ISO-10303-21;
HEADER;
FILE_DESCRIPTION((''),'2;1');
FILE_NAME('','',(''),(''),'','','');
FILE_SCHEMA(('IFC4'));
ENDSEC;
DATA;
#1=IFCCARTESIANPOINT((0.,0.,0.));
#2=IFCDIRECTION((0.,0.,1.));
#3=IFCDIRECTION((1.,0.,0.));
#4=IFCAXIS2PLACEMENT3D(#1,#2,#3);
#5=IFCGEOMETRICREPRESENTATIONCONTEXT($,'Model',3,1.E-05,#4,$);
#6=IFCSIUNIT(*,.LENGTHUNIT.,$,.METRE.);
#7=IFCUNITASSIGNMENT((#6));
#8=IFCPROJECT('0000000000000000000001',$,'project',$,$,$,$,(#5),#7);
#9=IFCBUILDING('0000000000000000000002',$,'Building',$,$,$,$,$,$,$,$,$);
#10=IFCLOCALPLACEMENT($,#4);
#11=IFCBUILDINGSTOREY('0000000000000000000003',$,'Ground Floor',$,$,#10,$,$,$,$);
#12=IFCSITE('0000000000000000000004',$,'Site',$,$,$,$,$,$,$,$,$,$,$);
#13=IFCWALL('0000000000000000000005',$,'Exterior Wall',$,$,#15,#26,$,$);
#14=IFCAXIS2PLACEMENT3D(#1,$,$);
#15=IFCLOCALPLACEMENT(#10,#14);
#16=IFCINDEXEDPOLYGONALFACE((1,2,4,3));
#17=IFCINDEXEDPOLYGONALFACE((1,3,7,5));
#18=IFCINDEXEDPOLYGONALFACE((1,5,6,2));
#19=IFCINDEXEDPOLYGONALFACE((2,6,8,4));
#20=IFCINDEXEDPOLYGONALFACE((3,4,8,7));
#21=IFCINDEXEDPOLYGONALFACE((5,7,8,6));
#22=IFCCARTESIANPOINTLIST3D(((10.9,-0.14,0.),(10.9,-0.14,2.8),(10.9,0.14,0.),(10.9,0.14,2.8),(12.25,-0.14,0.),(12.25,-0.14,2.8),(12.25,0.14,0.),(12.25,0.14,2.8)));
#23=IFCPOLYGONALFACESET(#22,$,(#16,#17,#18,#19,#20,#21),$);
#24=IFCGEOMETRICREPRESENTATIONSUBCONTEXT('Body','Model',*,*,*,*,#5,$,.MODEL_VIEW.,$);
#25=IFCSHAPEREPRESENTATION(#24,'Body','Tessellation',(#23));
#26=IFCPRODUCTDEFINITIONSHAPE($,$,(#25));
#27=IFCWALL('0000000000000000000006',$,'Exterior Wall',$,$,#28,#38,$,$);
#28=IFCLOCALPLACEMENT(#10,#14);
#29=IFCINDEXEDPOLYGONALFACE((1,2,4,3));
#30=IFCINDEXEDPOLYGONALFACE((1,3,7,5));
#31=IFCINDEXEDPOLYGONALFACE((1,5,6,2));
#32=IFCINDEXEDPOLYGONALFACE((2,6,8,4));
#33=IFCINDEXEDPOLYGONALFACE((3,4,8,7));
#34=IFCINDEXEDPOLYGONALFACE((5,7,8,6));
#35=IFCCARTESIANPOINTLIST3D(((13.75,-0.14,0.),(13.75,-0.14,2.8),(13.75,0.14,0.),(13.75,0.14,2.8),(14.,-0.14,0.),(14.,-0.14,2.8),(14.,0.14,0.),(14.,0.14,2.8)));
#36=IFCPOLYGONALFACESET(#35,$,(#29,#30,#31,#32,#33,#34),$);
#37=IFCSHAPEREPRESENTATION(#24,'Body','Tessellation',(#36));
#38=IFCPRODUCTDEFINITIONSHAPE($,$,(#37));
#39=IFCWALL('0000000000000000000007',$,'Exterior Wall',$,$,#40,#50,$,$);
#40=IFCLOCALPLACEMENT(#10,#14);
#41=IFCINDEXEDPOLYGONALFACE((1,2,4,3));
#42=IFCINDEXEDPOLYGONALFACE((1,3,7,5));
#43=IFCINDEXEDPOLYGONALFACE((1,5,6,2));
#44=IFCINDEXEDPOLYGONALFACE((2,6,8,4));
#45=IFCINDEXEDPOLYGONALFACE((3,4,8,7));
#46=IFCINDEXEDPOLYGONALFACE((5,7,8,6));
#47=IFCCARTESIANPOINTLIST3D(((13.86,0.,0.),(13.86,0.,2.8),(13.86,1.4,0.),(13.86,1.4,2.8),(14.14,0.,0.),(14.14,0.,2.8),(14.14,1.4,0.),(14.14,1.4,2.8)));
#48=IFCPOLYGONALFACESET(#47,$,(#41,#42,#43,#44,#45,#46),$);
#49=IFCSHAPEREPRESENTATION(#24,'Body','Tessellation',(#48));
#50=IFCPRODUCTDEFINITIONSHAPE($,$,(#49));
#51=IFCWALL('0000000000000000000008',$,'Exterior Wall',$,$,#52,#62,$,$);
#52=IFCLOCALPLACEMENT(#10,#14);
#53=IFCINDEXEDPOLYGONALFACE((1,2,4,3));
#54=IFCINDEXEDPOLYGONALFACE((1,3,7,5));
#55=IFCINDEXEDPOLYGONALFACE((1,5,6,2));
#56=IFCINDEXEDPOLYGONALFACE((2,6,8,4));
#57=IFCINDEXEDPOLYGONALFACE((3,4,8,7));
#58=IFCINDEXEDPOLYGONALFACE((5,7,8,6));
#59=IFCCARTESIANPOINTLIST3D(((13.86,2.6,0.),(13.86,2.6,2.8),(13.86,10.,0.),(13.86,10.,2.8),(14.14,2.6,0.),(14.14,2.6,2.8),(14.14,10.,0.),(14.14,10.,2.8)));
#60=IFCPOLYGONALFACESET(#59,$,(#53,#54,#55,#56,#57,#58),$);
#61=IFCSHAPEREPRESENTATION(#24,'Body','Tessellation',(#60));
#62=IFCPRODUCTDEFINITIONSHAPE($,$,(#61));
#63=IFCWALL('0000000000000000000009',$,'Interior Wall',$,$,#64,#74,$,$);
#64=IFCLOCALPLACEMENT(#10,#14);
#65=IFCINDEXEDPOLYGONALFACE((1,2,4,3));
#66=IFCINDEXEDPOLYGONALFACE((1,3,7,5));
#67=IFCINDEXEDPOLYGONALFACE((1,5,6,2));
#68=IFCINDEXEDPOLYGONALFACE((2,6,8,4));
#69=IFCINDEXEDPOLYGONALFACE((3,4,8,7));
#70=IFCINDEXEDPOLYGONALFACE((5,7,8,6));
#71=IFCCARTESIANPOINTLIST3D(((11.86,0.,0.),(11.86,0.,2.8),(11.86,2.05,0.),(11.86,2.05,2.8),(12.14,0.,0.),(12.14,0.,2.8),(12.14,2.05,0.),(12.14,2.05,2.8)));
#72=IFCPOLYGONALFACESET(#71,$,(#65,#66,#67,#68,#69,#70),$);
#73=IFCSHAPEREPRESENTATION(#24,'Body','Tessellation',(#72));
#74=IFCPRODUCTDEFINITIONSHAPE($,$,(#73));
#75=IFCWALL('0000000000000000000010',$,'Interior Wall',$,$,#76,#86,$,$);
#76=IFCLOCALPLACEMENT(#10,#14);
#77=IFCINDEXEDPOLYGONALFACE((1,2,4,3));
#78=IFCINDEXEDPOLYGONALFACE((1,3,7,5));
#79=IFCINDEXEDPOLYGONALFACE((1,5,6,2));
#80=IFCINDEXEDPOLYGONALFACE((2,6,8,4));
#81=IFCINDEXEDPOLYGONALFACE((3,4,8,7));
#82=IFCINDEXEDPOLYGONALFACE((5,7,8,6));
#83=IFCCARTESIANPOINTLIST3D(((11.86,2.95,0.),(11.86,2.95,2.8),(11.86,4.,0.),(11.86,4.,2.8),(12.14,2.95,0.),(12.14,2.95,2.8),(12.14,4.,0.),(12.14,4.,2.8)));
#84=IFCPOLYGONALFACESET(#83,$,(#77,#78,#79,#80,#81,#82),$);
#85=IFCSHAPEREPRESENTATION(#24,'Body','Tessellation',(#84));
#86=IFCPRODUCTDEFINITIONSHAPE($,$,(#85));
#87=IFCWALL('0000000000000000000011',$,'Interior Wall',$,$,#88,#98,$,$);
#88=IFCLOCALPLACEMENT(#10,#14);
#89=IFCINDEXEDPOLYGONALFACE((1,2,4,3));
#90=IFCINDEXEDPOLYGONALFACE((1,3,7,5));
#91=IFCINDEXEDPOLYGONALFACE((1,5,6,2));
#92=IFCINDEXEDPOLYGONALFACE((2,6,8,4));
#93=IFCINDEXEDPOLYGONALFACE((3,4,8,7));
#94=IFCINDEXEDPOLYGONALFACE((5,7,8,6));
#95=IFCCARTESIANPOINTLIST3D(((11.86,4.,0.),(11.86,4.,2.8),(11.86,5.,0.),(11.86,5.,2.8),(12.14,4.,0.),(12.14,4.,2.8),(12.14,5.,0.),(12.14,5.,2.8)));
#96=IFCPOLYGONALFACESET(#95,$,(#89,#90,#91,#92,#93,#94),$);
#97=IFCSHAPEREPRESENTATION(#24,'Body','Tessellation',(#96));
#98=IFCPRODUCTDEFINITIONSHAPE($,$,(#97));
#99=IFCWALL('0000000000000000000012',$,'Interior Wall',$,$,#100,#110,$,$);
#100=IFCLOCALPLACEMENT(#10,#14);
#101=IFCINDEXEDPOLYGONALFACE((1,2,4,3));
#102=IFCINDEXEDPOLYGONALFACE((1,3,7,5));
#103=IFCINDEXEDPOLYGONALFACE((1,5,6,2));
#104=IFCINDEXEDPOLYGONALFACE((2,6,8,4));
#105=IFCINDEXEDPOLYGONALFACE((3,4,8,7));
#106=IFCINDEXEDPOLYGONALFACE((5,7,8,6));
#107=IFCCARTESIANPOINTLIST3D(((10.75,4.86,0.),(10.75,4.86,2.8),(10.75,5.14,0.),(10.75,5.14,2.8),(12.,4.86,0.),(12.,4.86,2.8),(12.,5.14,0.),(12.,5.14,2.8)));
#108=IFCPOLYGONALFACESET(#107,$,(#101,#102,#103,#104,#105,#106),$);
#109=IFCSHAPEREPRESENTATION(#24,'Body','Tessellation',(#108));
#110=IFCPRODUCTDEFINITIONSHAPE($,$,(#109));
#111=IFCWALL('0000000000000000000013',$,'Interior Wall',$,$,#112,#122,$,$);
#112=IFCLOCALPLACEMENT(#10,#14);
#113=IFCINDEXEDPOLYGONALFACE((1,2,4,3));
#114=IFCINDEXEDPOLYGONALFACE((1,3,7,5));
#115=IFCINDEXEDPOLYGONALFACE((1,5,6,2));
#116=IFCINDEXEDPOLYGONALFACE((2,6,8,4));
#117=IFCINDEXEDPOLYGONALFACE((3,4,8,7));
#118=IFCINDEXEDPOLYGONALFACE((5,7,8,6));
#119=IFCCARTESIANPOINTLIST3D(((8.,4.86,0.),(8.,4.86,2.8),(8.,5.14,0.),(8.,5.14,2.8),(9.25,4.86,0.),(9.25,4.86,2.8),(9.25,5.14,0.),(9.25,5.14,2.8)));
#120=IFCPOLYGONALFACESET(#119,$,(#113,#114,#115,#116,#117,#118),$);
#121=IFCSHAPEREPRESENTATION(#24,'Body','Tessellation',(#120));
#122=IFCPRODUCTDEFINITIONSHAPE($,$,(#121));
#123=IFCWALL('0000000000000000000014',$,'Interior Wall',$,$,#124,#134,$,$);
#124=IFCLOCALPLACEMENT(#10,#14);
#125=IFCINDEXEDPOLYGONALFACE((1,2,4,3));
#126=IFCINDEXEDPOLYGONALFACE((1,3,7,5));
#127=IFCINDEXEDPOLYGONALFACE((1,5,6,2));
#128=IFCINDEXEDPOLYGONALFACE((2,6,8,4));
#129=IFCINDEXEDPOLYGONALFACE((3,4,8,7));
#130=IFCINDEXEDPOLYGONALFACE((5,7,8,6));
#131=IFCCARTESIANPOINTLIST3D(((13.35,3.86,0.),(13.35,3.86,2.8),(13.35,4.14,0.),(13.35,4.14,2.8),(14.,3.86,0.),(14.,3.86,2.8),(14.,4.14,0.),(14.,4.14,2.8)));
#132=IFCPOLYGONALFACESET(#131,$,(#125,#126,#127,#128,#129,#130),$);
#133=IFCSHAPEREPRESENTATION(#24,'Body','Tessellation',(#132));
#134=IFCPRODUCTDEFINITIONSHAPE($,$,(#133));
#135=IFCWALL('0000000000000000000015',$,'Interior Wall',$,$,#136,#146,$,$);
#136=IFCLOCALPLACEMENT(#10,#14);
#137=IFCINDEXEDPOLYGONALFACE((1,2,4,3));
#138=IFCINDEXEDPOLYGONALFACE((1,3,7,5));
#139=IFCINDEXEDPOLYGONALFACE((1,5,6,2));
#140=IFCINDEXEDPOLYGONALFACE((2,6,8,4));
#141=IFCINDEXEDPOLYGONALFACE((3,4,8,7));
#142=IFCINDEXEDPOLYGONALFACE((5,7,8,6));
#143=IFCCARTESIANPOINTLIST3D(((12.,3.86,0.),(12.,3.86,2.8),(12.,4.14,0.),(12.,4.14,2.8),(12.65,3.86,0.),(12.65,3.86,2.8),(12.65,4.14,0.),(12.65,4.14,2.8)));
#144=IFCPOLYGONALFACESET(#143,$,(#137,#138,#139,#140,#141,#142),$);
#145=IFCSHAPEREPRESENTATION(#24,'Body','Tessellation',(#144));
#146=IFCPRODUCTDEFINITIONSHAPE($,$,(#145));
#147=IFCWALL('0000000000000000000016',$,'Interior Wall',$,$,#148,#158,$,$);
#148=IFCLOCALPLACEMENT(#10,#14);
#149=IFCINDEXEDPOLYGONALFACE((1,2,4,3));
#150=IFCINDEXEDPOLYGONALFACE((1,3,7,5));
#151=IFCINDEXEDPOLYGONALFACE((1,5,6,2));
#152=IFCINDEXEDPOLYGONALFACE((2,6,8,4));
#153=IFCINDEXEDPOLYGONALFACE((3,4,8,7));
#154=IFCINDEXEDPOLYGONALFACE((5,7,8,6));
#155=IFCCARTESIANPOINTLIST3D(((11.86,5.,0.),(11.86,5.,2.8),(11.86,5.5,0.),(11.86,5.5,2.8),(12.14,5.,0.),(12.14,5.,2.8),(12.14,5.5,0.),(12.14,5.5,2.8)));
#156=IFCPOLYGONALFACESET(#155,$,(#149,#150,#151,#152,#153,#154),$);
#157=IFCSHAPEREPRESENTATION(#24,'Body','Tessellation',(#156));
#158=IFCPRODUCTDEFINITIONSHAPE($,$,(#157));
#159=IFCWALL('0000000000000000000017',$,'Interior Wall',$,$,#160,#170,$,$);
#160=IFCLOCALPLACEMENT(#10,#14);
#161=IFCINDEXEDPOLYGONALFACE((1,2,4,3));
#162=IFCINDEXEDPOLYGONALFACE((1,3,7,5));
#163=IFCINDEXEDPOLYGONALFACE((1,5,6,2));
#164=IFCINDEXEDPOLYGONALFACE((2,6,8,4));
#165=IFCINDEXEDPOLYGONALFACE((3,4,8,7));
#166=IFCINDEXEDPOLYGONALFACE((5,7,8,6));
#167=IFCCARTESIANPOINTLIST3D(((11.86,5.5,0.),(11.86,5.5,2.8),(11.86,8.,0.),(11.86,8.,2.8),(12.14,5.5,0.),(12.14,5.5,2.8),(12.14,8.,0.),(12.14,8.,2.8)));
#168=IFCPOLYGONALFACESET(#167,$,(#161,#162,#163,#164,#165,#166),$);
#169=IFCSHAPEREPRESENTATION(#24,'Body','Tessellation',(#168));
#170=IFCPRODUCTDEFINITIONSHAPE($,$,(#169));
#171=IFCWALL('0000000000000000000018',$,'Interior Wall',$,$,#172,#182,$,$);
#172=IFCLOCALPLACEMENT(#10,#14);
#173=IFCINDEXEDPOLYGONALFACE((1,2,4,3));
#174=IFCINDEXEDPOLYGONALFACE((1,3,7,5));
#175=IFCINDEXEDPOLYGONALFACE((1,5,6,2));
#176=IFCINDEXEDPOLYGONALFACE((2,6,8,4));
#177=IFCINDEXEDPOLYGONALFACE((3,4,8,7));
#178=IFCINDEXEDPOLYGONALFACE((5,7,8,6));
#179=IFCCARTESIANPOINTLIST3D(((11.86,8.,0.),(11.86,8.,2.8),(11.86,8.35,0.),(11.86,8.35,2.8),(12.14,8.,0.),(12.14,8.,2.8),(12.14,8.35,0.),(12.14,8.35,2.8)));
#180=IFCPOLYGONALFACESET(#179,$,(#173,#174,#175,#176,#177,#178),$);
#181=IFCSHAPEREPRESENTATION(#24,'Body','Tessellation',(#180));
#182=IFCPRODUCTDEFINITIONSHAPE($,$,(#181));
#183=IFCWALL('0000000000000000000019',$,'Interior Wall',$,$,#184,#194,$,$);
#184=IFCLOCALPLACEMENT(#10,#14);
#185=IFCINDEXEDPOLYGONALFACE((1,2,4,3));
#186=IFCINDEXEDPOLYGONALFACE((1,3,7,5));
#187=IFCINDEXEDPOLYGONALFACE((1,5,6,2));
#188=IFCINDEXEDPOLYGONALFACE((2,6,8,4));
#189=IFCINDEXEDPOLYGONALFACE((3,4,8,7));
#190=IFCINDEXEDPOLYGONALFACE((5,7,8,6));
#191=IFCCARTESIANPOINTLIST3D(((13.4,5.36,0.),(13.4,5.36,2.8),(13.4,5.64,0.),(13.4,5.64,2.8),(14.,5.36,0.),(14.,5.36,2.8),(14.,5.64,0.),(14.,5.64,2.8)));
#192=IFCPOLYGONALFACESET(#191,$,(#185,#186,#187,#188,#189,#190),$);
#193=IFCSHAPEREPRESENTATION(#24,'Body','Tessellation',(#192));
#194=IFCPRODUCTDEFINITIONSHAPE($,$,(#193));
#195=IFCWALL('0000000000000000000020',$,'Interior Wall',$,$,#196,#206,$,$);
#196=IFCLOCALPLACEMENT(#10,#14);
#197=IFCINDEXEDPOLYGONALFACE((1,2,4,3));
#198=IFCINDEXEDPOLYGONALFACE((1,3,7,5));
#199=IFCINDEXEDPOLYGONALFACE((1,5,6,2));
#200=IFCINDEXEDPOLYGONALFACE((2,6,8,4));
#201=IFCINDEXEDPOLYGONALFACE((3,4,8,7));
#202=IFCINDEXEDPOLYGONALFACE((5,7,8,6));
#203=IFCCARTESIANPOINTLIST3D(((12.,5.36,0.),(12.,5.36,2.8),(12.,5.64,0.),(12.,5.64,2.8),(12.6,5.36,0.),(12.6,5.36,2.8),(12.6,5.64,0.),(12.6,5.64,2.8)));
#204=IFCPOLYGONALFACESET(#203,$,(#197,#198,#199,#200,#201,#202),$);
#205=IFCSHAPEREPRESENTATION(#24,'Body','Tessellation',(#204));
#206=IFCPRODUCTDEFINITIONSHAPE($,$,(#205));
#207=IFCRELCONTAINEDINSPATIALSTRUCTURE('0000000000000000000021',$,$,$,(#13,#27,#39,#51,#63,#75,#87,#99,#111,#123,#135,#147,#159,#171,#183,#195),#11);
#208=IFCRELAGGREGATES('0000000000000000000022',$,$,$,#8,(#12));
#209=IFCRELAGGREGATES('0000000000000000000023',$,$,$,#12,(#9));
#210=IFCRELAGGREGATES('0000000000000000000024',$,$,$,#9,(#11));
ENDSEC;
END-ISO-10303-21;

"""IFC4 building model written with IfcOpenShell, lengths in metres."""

from ifc_helpers import new_model, si_unit, frame, origin_with_axes, place, context, subcontext, project, spatial, indexed_curve, outline, extrude, element, save


model = new_model("IFC4")

# Units and contexts
model_context = context("Model", 3, precision=1e-05, world=origin_with_axes())
body_context = subcontext(model_context, "Body", "Model", "MODEL_VIEW")
ifc_project = project(units=[si_unit("LENGTHUNIT", "METRE")], contexts=[model_context])

# Site, building, storey
site = spatial("IfcSite", under=ifc_project, Name="Site")
building = spatial("IfcBuilding", under=site, Name="Building")
storey_placement = place(None, origin_with_axes())
storey = spatial("IfcBuildingStorey", under=building, at=storey_placement, Name="Ground Floor")

# Walls
wall_1_placement = place(storey_placement, frame((10.9, 0.0, 0.0), z_axis=(0.0, 0.0, 1.0), x_axis=(1.0, 0.0, 0.0)))
element("IfcWall", 1, at=wall_1_placement, inside=storey, Name="Exterior Wall", context=body_context, shape_type="SweptSolid", body=[
    extrude(outline(indexed_curve([(0.0, 0.0), (0.0, 0.28), (1.35, 0.28), (1.35, 0.0), (0.0, 0.0)], self_intersect=False)), frame((0.0, -0.14, 0.0), z_axis=(0.0, 0.0, 1.0), x_axis=(1.0, 0.0, 0.0)), (0.0, 0.0, 1.0), 2.8),
])
wall_2_placement = place(storey_placement, frame((13.75, 0.0, 0.0), z_axis=(0.0, 0.0, 1.0), x_axis=(1.0, 0.0, 0.0)))
element("IfcWall", 2, at=wall_2_placement, inside=storey, Name="Exterior Wall", context=body_context, shape_type="SweptSolid", body=[
    extrude(outline(indexed_curve([(0.0, 0.0), (0.0, 0.28), (0.25, 0.28), (0.25, 0.0), (0.0, 0.0)], self_intersect=False)), frame((0.0, -0.14, 0.0), z_axis=(0.0, 0.0, 1.0), x_axis=(1.0, 0.0, 0.0)), (0.0, 0.0, 1.0), 2.8),
])
wall_3_placement = place(storey_placement, frame((14.0, 0.0, 0.0), z_axis=(0.0, 0.0, 1.0), x_axis=(0.0, 1.0, 0.0)))
element("IfcWall", 3, at=wall_3_placement, inside=storey, Name="Exterior Wall", context=body_context, shape_type="SweptSolid", body=[
    extrude(outline(indexed_curve([(0.0, 0.0), (0.0, 0.28), (1.4, 0.28), (1.4, 0.0), (0.0, 0.0)], self_intersect=False)), frame((0.0, -0.14, 0.0), z_axis=(0.0, 0.0, 1.0), x_axis=(1.0, 0.0, 0.0)), (0.0, 0.0, 1.0), 2.8),
])
wall_4_placement = place(storey_placement, frame((14.0, 2.6, 0.0), z_axis=(0.0, 0.0, 1.0), x_axis=(0.0, 1.0, 0.0)))
element("IfcWall", 4, at=wall_4_placement, inside=storey, Name="Exterior Wall", context=body_context, shape_type="SweptSolid", body=[
    extrude(outline(indexed_curve([(0.0, 0.0), (0.0, 0.28), (7.4, 0.28), (7.4, 0.0), (0.0, 0.0)], self_intersect=False)), frame((0.0, -0.14, 0.0), z_axis=(0.0, 0.0, 1.0), x_axis=(1.0, 0.0, 0.0)), (0.0, 0.0, 1.0), 2.8),
])
wall_5_placement = place(storey_placement, frame((12.0, 0.0, 0.0), z_axis=(0.0, 0.0, 1.0), x_axis=(0.0, 1.0, 0.0)))
element("IfcWall", 5, at=wall_5_placement, inside=storey, Name="Interior Wall", context=body_context, shape_type="SweptSolid", body=[
    extrude(outline(indexed_curve([(0.0, 0.0), (0.0, 0.28), (2.05, 0.28), (2.05, 0.0), (0.0, 0.0)], self_intersect=False)), frame((0.0, -0.14, 0.0), z_axis=(0.0, 0.0, 1.0), x_axis=(1.0, 0.0, 0.0)), (0.0, 0.0, 1.0), 2.8),
])
wall_6_placement = place(storey_placement, frame((12.0, 2.95, 0.0), z_axis=(0.0, 0.0, 1.0), x_axis=(0.0, 1.0, 0.0)))
element("IfcWall", 6, at=wall_6_placement, inside=storey, Name="Interior Wall", context=body_context, shape_type="SweptSolid", body=[
    extrude(outline(indexed_curve([(0.0, 0.0), (0.0, 0.28), (1.05, 0.28), (1.05, 0.0), (0.0, 0.0)], self_intersect=False)), frame((0.0, -0.14, 0.0), z_axis=(0.0, 0.0, 1.0), x_axis=(1.0, 0.0, 0.0)), (0.0, 0.0, 1.0), 2.8),
])
wall_7_placement = place(storey_placement, frame((12.0, 4.0, 0.0), z_axis=(0.0, 0.0, 1.0), x_axis=(0.0, 1.0, 0.0)))
element("IfcWall", 7, at=wall_7_placement, inside=storey, Name="Interior Wall", context=body_context, shape_type="SweptSolid", body=[
    extrude(outline(indexed_curve([(0.0, 0.0), (0.0, 0.28), (1.0, 0.28), (1.0, 0.0), (0.0, 0.0)], self_intersect=False)), frame((0.0, -0.14, 0.0), z_axis=(0.0, 0.0, 1.0), x_axis=(1.0, 0.0, 0.0)), (0.0, 0.0, 1.0), 2.8),
])
for number, where, z_axis, x_axis, name in (
    (8, (12.0, 5.0, 0.0), (0.0, 0.0, 1.0), (-1.0, 0.0, 0.0), "Interior Wall"),
    (9, (9.25, 5.0, 0.0), (0.0, 0.0, 1.0), (-1.0, 0.0, 0.0), "Interior Wall"),
):
    element("IfcWall", number, at=place(storey_placement, frame(where, z_axis=z_axis, x_axis=x_axis)), inside=storey, Name=name, context=body_context, shape_type="SweptSolid", body=[
        extrude(outline(indexed_curve([(0.0, 0.0), (0.0, 0.28), (1.25, 0.28), (1.25, 0.0), (0.0, 0.0)], self_intersect=False)), frame((0.0, -0.14, 0.0), z_axis=(0.0, 0.0, 1.0), x_axis=(1.0, 0.0, 0.0)), (0.0, 0.0, 1.0), 2.8),
    ])
for number, where, z_axis, x_axis, name in (
    (10, (14.0, 4.0, 0.0), (0.0, 0.0, 1.0), (-1.0, 0.0, 0.0), "Interior Wall"),
    (11, (12.65, 4.0, 0.0), (0.0, 0.0, 1.0), (-1.0, 0.0, 0.0), "Interior Wall"),
):
    element("IfcWall", number, at=place(storey_placement, frame(where, z_axis=z_axis, x_axis=x_axis)), inside=storey, Name=name, context=body_context, shape_type="SweptSolid", body=[
        extrude(outline(indexed_curve([(0.0, 0.0), (0.0, 0.28), (0.65, 0.28), (0.65, 0.0), (0.0, 0.0)], self_intersect=False)), frame((0.0, -0.14, 0.0), z_axis=(0.0, 0.0, 1.0), x_axis=(1.0, 0.0, 0.0)), (0.0, 0.0, 1.0), 2.8),
    ])
wall_8_placement = place(storey_placement, frame((12.0, 5.0, 0.0), z_axis=(0.0, 0.0, 1.0), x_axis=(0.0, 1.0, 0.0)))
element("IfcWall", 12, at=wall_8_placement, inside=storey, Name="Interior Wall", context=body_context, shape_type="SweptSolid", body=[
    extrude(outline(indexed_curve([(0.0, 0.0), (0.0, 0.28), (0.5, 0.28), (0.5, 0.0), (0.0, 0.0)], self_intersect=False)), frame((0.0, -0.14, 0.0), z_axis=(0.0, 0.0, 1.0), x_axis=(1.0, 0.0, 0.0)), (0.0, 0.0, 1.0), 2.8),
])
wall_9_placement = place(storey_placement, frame((12.0, 5.5, 0.0), z_axis=(0.0, 0.0, 1.0), x_axis=(0.0, 1.0, 0.0)))
element("IfcWall", 13, at=wall_9_placement, inside=storey, Name="Interior Wall", context=body_context, shape_type="SweptSolid", body=[
    extrude(outline(indexed_curve([(0.0, 0.0), (0.0, 0.28), (2.5, 0.28), (2.5, 0.0), (0.0, 0.0)], self_intersect=False)), frame((0.0, -0.14, 0.0), z_axis=(0.0, 0.0, 1.0), x_axis=(1.0, 0.0, 0.0)), (0.0, 0.0, 1.0), 2.8),
])
wall_10_placement = place(storey_placement, frame((12.0, 8.0, 0.0), z_axis=(0.0, 0.0, 1.0), x_axis=(0.0, 1.0, 0.0)))
element("IfcWall", 14, at=wall_10_placement, inside=storey, Name="Interior Wall", context=body_context, shape_type="SweptSolid", body=[
    extrude(outline(indexed_curve([(0.0, 0.0), (0.0, 0.28), (0.35, 0.28), (0.35, 0.0), (0.0, 0.0)], self_intersect=False)), frame((0.0, -0.14, 0.0), z_axis=(0.0, 0.0, 1.0), x_axis=(1.0, 0.0, 0.0)), (0.0, 0.0, 1.0), 2.8),
])
for number, where, z_axis, x_axis, name in (
    (15, (14.0, 5.5, 0.0), (0.0, 0.0, 1.0), (-1.0, 0.0, 0.0), "Interior Wall"),
    (16, (12.6, 5.5, 0.0), (0.0, 0.0, 1.0), (-1.0, 0.0, 0.0), "Interior Wall"),
):
    element("IfcWall", number, at=place(storey_placement, frame(where, z_axis=z_axis, x_axis=x_axis)), inside=storey, Name=name, context=body_context, shape_type="SweptSolid", body=[
        extrude(outline(indexed_curve([(0.0, 0.0), (0.0, 0.28), (0.6, 0.28), (0.6, 0.0), (0.0, 0.0)], self_intersect=False)), frame((0.0, -0.14, 0.0), z_axis=(0.0, 0.0, 1.0), x_axis=(1.0, 0.0, 0.0)), (0.0, 0.0, 1.0), 2.8),
    ])

save(model, "model.ifc")
